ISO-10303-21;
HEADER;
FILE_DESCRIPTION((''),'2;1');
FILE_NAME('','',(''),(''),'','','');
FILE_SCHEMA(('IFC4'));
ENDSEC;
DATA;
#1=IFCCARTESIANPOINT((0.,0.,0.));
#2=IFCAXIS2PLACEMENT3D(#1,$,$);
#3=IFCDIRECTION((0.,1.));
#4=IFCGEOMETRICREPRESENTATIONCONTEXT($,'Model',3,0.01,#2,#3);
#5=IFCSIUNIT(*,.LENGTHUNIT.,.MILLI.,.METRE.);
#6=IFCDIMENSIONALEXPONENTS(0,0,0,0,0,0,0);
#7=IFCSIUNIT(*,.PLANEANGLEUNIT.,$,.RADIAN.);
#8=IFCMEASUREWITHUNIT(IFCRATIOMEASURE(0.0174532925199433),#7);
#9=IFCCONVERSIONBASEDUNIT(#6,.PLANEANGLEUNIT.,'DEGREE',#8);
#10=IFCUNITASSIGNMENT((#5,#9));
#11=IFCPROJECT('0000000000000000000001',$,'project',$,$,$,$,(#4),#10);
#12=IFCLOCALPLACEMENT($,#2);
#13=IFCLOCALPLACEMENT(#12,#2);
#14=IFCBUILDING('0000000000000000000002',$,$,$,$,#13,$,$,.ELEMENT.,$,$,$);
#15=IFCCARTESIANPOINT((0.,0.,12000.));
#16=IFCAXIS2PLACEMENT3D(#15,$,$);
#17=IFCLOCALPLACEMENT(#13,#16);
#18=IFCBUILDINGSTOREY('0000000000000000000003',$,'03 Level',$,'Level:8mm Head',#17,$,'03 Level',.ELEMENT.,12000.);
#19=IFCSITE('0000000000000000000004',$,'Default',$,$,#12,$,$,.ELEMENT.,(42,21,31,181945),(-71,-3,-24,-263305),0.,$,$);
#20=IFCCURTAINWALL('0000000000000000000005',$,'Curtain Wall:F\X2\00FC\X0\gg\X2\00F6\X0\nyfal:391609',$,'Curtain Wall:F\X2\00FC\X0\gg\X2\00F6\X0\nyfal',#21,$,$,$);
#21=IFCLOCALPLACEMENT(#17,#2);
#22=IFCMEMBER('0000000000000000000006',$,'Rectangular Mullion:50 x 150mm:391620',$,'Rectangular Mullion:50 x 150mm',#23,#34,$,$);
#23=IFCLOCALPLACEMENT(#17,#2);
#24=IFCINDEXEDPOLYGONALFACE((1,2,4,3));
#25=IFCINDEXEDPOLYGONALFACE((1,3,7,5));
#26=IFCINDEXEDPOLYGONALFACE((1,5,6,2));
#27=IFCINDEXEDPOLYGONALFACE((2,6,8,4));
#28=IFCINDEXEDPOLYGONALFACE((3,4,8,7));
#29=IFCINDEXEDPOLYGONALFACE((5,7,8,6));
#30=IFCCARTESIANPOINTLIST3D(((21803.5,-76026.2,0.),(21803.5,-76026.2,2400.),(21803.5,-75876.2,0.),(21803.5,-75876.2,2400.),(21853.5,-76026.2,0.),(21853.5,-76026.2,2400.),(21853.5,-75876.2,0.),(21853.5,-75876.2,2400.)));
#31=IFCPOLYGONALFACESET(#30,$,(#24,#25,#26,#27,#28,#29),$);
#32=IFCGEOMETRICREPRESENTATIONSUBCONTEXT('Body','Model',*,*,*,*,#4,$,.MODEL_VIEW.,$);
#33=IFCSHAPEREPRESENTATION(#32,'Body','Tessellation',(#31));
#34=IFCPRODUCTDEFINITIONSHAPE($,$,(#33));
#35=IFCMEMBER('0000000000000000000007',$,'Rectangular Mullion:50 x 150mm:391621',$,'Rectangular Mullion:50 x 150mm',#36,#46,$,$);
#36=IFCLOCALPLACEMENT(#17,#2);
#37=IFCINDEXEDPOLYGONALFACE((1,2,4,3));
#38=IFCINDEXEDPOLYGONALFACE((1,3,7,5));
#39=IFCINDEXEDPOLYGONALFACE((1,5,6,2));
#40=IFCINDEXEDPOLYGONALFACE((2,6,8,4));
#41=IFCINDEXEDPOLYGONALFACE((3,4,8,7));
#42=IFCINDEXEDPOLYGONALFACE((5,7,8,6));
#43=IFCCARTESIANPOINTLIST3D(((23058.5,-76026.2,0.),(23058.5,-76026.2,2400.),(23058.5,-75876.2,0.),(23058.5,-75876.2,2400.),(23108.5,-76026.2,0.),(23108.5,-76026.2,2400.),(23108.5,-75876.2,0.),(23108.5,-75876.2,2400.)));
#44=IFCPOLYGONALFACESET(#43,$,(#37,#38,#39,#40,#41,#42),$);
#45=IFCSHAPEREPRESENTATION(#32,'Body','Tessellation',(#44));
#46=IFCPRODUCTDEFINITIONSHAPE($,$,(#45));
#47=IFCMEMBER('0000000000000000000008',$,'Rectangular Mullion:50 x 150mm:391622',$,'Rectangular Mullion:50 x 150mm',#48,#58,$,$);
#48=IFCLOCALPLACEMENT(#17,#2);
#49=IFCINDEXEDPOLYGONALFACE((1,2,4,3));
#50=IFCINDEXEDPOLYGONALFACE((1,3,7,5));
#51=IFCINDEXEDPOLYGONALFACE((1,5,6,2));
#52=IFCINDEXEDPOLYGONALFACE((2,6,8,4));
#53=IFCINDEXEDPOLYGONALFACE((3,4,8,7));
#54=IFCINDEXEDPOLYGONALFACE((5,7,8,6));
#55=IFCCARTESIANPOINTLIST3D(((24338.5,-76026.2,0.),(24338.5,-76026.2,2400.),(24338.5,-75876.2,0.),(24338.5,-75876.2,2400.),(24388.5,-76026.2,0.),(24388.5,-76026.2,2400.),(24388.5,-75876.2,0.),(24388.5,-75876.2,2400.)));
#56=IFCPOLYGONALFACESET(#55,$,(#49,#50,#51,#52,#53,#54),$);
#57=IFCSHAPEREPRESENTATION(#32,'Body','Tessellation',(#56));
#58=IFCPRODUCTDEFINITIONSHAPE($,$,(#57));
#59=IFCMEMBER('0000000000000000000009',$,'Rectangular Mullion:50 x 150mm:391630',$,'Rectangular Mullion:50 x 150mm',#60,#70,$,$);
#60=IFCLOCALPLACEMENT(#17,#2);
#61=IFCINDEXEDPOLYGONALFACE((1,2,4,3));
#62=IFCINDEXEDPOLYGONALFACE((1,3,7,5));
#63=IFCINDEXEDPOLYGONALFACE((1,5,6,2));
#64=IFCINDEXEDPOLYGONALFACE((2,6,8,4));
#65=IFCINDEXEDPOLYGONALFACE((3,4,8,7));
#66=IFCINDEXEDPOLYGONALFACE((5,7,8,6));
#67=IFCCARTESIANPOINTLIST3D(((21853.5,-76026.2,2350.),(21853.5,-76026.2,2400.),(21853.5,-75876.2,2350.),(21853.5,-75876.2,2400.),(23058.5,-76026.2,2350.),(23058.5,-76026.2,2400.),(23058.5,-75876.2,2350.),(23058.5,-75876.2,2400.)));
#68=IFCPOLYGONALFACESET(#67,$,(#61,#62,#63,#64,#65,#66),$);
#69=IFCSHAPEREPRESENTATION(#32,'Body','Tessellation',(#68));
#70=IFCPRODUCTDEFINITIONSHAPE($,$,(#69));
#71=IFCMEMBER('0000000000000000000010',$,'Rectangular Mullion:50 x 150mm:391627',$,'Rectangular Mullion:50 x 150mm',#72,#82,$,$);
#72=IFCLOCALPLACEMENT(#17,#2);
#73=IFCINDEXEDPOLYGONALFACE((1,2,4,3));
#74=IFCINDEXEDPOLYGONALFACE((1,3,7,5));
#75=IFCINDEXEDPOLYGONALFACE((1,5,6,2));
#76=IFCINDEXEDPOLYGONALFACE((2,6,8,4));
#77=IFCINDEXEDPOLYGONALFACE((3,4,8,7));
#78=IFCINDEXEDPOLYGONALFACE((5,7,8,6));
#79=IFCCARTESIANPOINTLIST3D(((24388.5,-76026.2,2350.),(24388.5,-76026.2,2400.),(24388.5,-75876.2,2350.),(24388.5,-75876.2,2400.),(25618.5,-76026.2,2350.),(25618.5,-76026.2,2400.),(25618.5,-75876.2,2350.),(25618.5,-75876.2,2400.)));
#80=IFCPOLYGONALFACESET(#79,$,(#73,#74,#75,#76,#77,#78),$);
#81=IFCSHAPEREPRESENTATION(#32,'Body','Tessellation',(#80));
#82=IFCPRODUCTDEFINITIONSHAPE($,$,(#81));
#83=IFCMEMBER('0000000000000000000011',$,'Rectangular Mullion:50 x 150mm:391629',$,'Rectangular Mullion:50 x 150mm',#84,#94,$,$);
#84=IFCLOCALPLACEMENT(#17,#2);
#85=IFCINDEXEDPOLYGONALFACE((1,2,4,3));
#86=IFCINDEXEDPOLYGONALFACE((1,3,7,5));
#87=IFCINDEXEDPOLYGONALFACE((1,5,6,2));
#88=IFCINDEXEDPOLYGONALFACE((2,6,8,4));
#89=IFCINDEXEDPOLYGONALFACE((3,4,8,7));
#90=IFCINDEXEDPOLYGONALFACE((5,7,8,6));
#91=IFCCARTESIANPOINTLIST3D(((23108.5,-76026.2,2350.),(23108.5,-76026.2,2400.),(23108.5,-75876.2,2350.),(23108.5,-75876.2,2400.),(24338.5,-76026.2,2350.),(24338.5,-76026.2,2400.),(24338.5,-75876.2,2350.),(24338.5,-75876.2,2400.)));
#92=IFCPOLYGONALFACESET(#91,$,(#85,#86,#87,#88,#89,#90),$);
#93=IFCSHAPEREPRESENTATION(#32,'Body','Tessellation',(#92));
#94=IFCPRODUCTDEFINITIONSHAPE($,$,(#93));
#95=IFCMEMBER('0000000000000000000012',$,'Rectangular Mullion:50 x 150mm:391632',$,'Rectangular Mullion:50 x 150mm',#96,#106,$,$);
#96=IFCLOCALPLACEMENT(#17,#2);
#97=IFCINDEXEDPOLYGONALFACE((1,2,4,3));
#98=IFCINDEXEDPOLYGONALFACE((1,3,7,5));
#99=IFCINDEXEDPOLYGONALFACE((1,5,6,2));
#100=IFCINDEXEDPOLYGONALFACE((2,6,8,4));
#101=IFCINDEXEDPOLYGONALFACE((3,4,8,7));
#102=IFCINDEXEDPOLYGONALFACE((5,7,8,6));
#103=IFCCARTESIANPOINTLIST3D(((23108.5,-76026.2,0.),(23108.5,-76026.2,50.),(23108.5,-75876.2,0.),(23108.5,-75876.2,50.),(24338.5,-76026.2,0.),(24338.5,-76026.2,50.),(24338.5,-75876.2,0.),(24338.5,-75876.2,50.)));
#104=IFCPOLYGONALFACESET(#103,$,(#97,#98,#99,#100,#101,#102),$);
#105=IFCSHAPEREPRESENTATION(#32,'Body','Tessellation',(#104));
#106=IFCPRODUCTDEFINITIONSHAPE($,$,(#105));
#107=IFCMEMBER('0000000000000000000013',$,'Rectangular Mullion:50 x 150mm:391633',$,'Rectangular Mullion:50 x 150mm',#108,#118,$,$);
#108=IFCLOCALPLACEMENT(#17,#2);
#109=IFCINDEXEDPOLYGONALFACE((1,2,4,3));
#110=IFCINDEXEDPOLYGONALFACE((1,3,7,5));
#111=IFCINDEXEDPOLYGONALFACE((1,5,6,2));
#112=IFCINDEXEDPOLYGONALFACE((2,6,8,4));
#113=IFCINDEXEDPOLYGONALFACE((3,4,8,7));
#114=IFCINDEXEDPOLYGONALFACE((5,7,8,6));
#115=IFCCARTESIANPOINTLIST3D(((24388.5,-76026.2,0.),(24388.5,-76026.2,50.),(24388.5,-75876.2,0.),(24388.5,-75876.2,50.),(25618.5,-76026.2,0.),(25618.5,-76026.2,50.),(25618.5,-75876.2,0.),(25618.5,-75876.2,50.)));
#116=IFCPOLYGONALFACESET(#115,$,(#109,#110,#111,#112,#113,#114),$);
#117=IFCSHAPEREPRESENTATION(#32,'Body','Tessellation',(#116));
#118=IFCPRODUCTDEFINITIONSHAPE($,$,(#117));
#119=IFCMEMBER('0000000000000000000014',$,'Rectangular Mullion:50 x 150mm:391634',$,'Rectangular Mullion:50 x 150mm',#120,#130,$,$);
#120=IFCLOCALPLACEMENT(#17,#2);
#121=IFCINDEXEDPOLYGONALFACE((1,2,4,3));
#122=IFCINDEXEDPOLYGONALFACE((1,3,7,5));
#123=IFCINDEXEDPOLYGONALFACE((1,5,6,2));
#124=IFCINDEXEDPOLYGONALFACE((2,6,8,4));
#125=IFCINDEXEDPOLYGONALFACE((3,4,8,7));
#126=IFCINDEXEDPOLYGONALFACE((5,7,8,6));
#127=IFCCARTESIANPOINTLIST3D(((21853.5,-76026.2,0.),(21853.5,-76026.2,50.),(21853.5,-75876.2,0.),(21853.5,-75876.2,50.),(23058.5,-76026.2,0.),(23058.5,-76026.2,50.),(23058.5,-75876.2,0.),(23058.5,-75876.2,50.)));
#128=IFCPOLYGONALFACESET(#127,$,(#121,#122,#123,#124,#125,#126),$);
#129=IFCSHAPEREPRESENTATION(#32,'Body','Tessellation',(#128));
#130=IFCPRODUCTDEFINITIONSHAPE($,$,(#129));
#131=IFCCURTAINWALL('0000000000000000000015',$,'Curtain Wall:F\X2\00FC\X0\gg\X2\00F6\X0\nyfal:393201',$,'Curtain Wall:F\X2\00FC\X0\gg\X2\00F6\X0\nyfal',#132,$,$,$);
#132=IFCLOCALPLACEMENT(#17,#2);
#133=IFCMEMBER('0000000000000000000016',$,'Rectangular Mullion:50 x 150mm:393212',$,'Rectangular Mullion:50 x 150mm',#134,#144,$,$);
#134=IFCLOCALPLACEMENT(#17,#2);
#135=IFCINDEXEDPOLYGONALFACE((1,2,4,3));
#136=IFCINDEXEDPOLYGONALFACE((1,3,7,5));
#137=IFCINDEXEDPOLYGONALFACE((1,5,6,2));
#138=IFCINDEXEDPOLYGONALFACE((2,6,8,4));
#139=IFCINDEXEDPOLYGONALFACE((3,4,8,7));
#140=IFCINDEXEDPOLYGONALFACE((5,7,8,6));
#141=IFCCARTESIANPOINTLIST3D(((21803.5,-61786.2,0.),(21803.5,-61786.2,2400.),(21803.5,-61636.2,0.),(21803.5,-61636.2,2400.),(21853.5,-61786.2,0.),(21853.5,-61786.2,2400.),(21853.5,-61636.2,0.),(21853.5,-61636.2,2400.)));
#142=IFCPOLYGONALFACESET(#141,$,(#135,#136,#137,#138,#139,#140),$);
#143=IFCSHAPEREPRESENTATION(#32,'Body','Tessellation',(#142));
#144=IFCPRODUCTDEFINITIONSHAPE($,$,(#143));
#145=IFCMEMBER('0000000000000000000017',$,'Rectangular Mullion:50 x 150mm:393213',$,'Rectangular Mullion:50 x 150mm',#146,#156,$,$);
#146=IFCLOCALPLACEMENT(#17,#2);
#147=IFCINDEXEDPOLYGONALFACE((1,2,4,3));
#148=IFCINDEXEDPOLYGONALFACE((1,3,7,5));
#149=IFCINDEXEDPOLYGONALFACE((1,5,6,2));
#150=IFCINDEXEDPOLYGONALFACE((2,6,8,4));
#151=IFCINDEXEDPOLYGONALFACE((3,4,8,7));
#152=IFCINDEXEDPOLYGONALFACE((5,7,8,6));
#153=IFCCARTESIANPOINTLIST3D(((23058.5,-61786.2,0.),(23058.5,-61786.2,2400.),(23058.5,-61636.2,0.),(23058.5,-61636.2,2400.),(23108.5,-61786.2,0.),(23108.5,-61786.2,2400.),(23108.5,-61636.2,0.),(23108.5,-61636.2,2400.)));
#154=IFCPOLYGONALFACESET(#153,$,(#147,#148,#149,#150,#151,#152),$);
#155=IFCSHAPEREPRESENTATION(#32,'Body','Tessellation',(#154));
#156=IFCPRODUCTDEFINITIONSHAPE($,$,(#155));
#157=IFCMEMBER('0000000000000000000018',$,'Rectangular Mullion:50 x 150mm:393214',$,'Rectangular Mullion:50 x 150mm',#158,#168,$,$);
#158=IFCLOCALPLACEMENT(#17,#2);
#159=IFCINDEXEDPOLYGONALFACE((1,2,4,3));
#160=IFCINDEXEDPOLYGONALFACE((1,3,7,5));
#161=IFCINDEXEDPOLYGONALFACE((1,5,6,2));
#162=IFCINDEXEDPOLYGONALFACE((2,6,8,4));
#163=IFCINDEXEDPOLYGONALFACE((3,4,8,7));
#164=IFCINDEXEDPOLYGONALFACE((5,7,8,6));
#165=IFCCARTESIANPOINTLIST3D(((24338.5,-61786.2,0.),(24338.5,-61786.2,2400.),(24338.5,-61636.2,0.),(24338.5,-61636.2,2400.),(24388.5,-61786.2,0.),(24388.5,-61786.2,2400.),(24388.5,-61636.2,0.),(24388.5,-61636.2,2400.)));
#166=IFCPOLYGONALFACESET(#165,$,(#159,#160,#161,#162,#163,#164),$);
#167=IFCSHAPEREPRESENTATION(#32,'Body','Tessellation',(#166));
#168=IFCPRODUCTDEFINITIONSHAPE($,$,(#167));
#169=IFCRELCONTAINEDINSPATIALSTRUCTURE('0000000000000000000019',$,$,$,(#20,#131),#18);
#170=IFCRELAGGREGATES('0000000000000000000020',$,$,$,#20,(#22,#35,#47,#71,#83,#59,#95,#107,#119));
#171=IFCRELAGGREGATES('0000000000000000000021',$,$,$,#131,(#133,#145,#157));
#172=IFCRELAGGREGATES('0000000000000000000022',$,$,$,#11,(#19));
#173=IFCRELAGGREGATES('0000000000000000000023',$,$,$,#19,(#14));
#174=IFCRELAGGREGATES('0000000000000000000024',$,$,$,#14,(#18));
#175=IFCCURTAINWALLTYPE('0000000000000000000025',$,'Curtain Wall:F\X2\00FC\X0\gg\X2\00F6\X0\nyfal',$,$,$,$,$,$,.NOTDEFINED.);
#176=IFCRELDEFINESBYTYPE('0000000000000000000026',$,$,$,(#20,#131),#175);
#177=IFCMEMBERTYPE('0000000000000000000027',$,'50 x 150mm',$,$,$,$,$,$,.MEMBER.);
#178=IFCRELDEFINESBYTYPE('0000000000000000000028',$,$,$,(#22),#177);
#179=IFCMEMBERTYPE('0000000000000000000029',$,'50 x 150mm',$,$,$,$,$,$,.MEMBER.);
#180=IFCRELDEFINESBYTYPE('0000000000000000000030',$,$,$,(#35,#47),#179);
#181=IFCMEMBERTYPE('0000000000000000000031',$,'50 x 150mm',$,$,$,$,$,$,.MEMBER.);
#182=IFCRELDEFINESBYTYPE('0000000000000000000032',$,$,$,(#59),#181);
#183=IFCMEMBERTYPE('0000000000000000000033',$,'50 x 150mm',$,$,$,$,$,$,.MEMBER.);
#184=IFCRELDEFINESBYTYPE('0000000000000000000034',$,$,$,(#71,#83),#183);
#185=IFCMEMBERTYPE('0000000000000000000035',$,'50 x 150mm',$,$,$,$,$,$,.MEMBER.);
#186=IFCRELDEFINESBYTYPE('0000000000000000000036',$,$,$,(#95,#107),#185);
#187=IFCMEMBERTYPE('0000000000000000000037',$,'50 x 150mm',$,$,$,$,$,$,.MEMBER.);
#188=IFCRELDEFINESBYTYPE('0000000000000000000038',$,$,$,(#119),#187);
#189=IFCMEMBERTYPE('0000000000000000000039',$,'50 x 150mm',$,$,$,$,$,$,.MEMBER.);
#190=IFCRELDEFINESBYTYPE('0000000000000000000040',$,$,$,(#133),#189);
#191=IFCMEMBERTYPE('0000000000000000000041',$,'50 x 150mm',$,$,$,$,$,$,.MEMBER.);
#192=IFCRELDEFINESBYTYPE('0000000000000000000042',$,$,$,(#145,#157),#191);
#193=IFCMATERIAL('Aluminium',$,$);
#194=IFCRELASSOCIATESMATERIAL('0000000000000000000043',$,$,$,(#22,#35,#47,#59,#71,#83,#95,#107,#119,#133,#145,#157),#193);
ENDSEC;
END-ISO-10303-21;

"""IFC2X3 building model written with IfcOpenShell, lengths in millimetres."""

from ifc_helpers import new_model, entity, si_unit, converted_unit, direction, frame, origin, origin_2d_with_axis, place, context, subcontext, project, spatial, rectangle, extrude, source, transform, mapped, material, type_object, type_shapes, element, aggregate, save


model = new_model("IFC2X3")

# Units and contexts
model_context = context("Model", 3, precision=0.01, world=origin(), true_north=direction((0.0, 1.0)))
body_context = subcontext(model_context, "Body", "Model", "MODEL_VIEW")
ifc_project = project(units=[si_unit("LENGTHUNIT", "METRE", prefix="MILLI"), converted_unit("PLANEANGLEUNIT", "DEGREE", entity("IfcRatioMeasure", 0.0174532925199433), si_unit("PLANEANGLEUNIT", "RADIAN"), dimensions=[0, 0, 0, 0, 0, 0, 0])], contexts=[model_context])

# Site, building, storey
site_placement = place(None, origin())
site = spatial("IfcSite", under=ifc_project, at=site_placement, Name="Default", CompositionType="ELEMENT", RefLatitude=(42, 21, 31, 181945), RefLongitude=(-71, -3, -24, -263305), RefElevation=0.0)
building_placement = place(site_placement, origin())
building = spatial("IfcBuilding", under=site, at=building_placement, CompositionType="ELEMENT")
storey_placement = place(building_placement, frame((0.0, 0.0, 12000.0)))
storey = spatial("IfcBuildingStorey", under=building, at=storey_placement, Name="03 Level", ObjectType="Level:8mm Head", LongName="03 Level", CompositionType="ELEMENT", Elevation=12000.0)

# Curtain walls, members
curtain_wall_type = type_object("IfcCurtainWallType", Name="Curtain Wall:Függönyfal", PredefinedType="NOTDEFINED")
curtain_wall_1_placement = place(storey_placement, frame((0.0, 0.0, -12000.0)))
curtain_wall_1 = element("IfcCurtainWall", 1, at=curtain_wall_1_placement, inside=storey, type_object=curtain_wall_type, Name="Curtain Wall:Függönyfal:391609", ObjectType="Curtain Wall:Függönyfal")
ifc_material_1 = material(Name="Aluminium")
member_type_1 = type_object("IfcMemberType", Name="50 x 150mm", PredefinedType="MEMBER")
shared_shape_1 = source(origin(), body_context, "Body", "SweptSolid", [
    extrude(rectangle(XDim=150.0, YDim=50.0, at=origin_2d_with_axis()), frame((-25.0, 0.0, -2400.0), z_axis=(0.0, 0.0, 1.0), x_axis=(0.0, -1.0, 0.0)), (0.0, 0.0, 1.0), 2400.0),
])
type_shapes(member_type_1, [shared_shape_1])
member_1_placement = place(storey_placement, frame((21803.5, -75951.2, 0.0), z_axis=(0.0, 0.0, -1.0), x_axis=(-1.0, 0.0, 0.0)))
member_1 = element("IfcMember", 2, at=member_1_placement, type_object=member_type_1, material=ifc_material_1, Name="Rectangular Mullion:50 x 150mm:391620", ObjectType="Rectangular Mullion:50 x 150mm", context=body_context, shape_type="MappedRepresentation", body=[
    mapped(shared_shape_1, transform((0.0, 0.0, 0.0), scale=1.0)),
])
member_type_2 = type_object("IfcMemberType", Name="50 x 150mm", PredefinedType="MEMBER")
shared_shape_2 = source(origin(), body_context, "Body", "SweptSolid", [
    extrude(rectangle(XDim=150.0, YDim=50.0, at=origin_2d_with_axis()), frame((0.0, 0.0, -2400.0), z_axis=(0.0, 0.0, 1.0), x_axis=(0.0, -1.0, 0.0)), (0.0, 0.0, 1.0), 2400.0),
])
type_shapes(member_type_2, [shared_shape_2])
member_2_placement = place(storey_placement, frame((23083.5, -75951.2, 0.0), z_axis=(0.0, 0.0, -1.0), x_axis=(-1.0, 0.0, 0.0)))
member_2 = element("IfcMember", 3, at=member_2_placement, type_object=member_type_2, material=ifc_material_1, Name="Rectangular Mullion:50 x 150mm:391621", ObjectType="Rectangular Mullion:50 x 150mm", context=body_context, shape_type="MappedRepresentation", body=[
    mapped(shared_shape_2, transform((0.0, 0.0, 0.0), scale=1.0)),
])
member_3_placement = place(storey_placement, frame((24363.5, -75951.2, 0.0), z_axis=(0.0, 0.0, -1.0), x_axis=(-1.0, 0.0, 0.0)))
member_3 = element("IfcMember", 4, at=member_3_placement, type_object=member_type_2, material=ifc_material_1, Name="Rectangular Mullion:50 x 150mm:391622", ObjectType="Rectangular Mullion:50 x 150mm", context=body_context, shape_type="MappedRepresentation", body=[
    mapped(shared_shape_2, transform((0.0, 0.0, 0.0), scale=1.0)),
])
member_type_3 = type_object("IfcMemberType", Name="50 x 150mm", PredefinedType="MEMBER")
shared_shape_3 = source(origin(), body_context, "Body", "SweptSolid", [
    extrude(rectangle(XDim=150.0, YDim=50.0, at=origin_2d_with_axis()), frame((-25.0, 0.0, -1205.0), z_axis=(0.0, 0.0, 1.0), x_axis=(0.0, -1.0, 0.0)), (0.0, 0.0, 1.0), 1205.0),
])
type_shapes(member_type_3, [shared_shape_3])
member_4_placement = place(storey_placement, frame((21853.5, -75951.2, 2400.0), z_axis=(-1.0, 0.0, 0.0), x_axis=(0.0, 0.0, 1.0)))
member_4 = element("IfcMember", 5, at=member_4_placement, type_object=member_type_3, material=ifc_material_1, Name="Rectangular Mullion:50 x 150mm:391630", ObjectType="Rectangular Mullion:50 x 150mm", context=body_context, shape_type="MappedRepresentation", body=[
    mapped(shared_shape_3, transform((0.0, 0.0, 0.0), scale=1.0)),
])
member_type_4 = type_object("IfcMemberType", Name="50 x 150mm", PredefinedType="MEMBER")
shared_shape_4 = source(origin(), body_context, "Body", "SweptSolid", [
    extrude(rectangle(XDim=150.0, YDim=50.0, at=origin_2d_with_axis()), frame((-25.0, 0.0, -1230.0), z_axis=(0.0, 0.0, 1.0), x_axis=(0.0, -1.0, 0.0)), (0.0, 0.0, 1.0), 1230.0),
])
type_shapes(member_type_4, [shared_shape_4])
member_5_placement = place(storey_placement, frame((24388.5, -75951.2, 2400.0), z_axis=(-1.0, 0.0, 0.0), x_axis=(0.0, 0.0, 1.0)))
member_5 = element("IfcMember", 6, at=member_5_placement, type_object=member_type_4, material=ifc_material_1, Name="Rectangular Mullion:50 x 150mm:391627", ObjectType="Rectangular Mullion:50 x 150mm", context=body_context, shape_type="MappedRepresentation", body=[
    mapped(shared_shape_4, transform((0.0, 0.0, 0.0), scale=1.0)),
])
member_6_placement = place(storey_placement, frame((23108.5, -75951.2, 2400.0), z_axis=(-1.0, 0.0, 0.0), x_axis=(0.0, 0.0, 1.0)))
member_6 = element("IfcMember", 7, at=member_6_placement, type_object=member_type_4, material=ifc_material_1, Name="Rectangular Mullion:50 x 150mm:391629", ObjectType="Rectangular Mullion:50 x 150mm", context=body_context, shape_type="MappedRepresentation", body=[
    mapped(shared_shape_4, transform((0.0, 0.0, 0.0), scale=1.0)),
])
member_type_5 = type_object("IfcMemberType", Name="50 x 150mm", PredefinedType="MEMBER")
shared_shape_5 = source(origin(), body_context, "Body", "SweptSolid", [
    extrude(rectangle(XDim=150.0, YDim=50.0, at=origin_2d_with_axis()), frame((-25.0, 0.0, -1230.0), z_axis=(0.0, 0.0, 1.0), x_axis=(0.0, -1.0, 0.0)), (0.0, 0.0, 1.0), 1230.0),
])
type_shapes(member_type_5, [shared_shape_5])
member_7_placement = place(storey_placement, frame((24338.5, -75951.2, 0.0), z_axis=(1.0, 0.0, 0.0), x_axis=(0.0, 0.0, -1.0)))
member_7 = element("IfcMember", 8, at=member_7_placement, type_object=member_type_5, material=ifc_material_1, Name="Rectangular Mullion:50 x 150mm:391632", ObjectType="Rectangular Mullion:50 x 150mm", context=body_context, shape_type="MappedRepresentation", body=[
    mapped(shared_shape_5, transform((0.0, 0.0, 0.0), scale=1.0)),
])
member_8_placement = place(storey_placement, frame((25618.5, -75951.2, 0.0), z_axis=(1.0, 0.0, 0.0), x_axis=(0.0, 0.0, -1.0)))
member_8 = element("IfcMember", 9, at=member_8_placement, type_object=member_type_5, material=ifc_material_1, Name="Rectangular Mullion:50 x 150mm:391633", ObjectType="Rectangular Mullion:50 x 150mm", context=body_context, shape_type="MappedRepresentation", body=[
    mapped(shared_shape_5, transform((0.0, 0.0, 0.0), scale=1.0)),
])
member_type_6 = type_object("IfcMemberType", Name="50 x 150mm", PredefinedType="MEMBER")
shared_shape_6 = source(origin(), body_context, "Body", "SweptSolid", [
    extrude(rectangle(XDim=150.0, YDim=50.0, at=origin_2d_with_axis()), frame((-25.0, 0.0, -1205.0), z_axis=(0.0, 0.0, 1.0), x_axis=(0.0, -1.0, 0.0)), (0.0, 0.0, 1.0), 1205.0),
])
type_shapes(member_type_6, [shared_shape_6])
member_9_placement = place(storey_placement, frame((23058.5, -75951.2, 0.0), z_axis=(1.0, 0.0, 0.0), x_axis=(0.0, 0.0, -1.0)))
member_9 = element("IfcMember", 10, at=member_9_placement, type_object=member_type_6, material=ifc_material_1, Name="Rectangular Mullion:50 x 150mm:391634", ObjectType="Rectangular Mullion:50 x 150mm", context=body_context, shape_type="MappedRepresentation", body=[
    mapped(shared_shape_6, transform((0.0, 0.0, 0.0), scale=1.0)),
])
curtain_wall_2_placement = place(storey_placement, frame((0.0, 0.0, -12000.0)))
curtain_wall_2 = element("IfcCurtainWall", 11, at=curtain_wall_2_placement, inside=storey, type_object=curtain_wall_type, Name="Curtain Wall:Függönyfal:393201", ObjectType="Curtain Wall:Függönyfal")
member_type_7 = type_object("IfcMemberType", Name="50 x 150mm", PredefinedType="MEMBER")
shared_shape_7 = source(origin(), body_context, "Body", "SweptSolid", [
    extrude(rectangle(XDim=150.0, YDim=50.0, at=origin_2d_with_axis()), frame((-25.0, 0.0, -2400.0), z_axis=(0.0, 0.0, 1.0), x_axis=(0.0, -1.0, 0.0)), (0.0, 0.0, 1.0), 2400.0),
])
type_shapes(member_type_7, [shared_shape_7])
member_10_placement = place(storey_placement, frame((21803.5, -61711.2, 0.0), z_axis=(0.0, 0.0, -1.0), x_axis=(-1.0, 0.0, 0.0)))
member_10 = element("IfcMember", 12, at=member_10_placement, type_object=member_type_7, material=ifc_material_1, Name="Rectangular Mullion:50 x 150mm:393212", ObjectType="Rectangular Mullion:50 x 150mm", context=body_context, shape_type="MappedRepresentation", body=[
    mapped(shared_shape_7, transform((0.0, 0.0, 0.0), scale=1.0)),
])
member_type_8 = type_object("IfcMemberType", Name="50 x 150mm", PredefinedType="MEMBER")
shared_shape_8 = source(origin(), body_context, "Body", "SweptSolid", [
    extrude(rectangle(XDim=150.0, YDim=50.0, at=origin_2d_with_axis()), frame((0.0, 0.0, -2400.0), z_axis=(0.0, 0.0, 1.0), x_axis=(0.0, -1.0, 0.0)), (0.0, 0.0, 1.0), 2400.0),
])
type_shapes(member_type_8, [shared_shape_8])
member_11_placement = place(storey_placement, frame((23083.5, -61711.2, 0.0), z_axis=(0.0, 0.0, -1.0), x_axis=(-1.0, 0.0, 0.0)))
member_11 = element("IfcMember", 13, at=member_11_placement, type_object=member_type_8, material=ifc_material_1, Name="Rectangular Mullion:50 x 150mm:393213", ObjectType="Rectangular Mullion:50 x 150mm", context=body_context, shape_type="MappedRepresentation", body=[
    mapped(shared_shape_8, transform((0.0, 0.0, 0.0), scale=1.0)),
])
member_12_placement = place(storey_placement, frame((24363.5, -61711.2, 0.0), z_axis=(0.0, 0.0, -1.0), x_axis=(-1.0, 0.0, 0.0)))
member_12 = element("IfcMember", 14, at=member_12_placement, type_object=member_type_8, material=ifc_material_1, Name="Rectangular Mullion:50 x 150mm:393214", ObjectType="Rectangular Mullion:50 x 150mm", context=body_context, shape_type="MappedRepresentation", body=[
    mapped(shared_shape_8, transform((0.0, 0.0, 0.0), scale=1.0)),
])

aggregate(curtain_wall_1, [member_1, member_2, member_3, member_5, member_6, member_4, member_7, member_8, member_9])
aggregate(curtain_wall_2, [member_10, member_11, member_12])

save(model, "model.ifc")
